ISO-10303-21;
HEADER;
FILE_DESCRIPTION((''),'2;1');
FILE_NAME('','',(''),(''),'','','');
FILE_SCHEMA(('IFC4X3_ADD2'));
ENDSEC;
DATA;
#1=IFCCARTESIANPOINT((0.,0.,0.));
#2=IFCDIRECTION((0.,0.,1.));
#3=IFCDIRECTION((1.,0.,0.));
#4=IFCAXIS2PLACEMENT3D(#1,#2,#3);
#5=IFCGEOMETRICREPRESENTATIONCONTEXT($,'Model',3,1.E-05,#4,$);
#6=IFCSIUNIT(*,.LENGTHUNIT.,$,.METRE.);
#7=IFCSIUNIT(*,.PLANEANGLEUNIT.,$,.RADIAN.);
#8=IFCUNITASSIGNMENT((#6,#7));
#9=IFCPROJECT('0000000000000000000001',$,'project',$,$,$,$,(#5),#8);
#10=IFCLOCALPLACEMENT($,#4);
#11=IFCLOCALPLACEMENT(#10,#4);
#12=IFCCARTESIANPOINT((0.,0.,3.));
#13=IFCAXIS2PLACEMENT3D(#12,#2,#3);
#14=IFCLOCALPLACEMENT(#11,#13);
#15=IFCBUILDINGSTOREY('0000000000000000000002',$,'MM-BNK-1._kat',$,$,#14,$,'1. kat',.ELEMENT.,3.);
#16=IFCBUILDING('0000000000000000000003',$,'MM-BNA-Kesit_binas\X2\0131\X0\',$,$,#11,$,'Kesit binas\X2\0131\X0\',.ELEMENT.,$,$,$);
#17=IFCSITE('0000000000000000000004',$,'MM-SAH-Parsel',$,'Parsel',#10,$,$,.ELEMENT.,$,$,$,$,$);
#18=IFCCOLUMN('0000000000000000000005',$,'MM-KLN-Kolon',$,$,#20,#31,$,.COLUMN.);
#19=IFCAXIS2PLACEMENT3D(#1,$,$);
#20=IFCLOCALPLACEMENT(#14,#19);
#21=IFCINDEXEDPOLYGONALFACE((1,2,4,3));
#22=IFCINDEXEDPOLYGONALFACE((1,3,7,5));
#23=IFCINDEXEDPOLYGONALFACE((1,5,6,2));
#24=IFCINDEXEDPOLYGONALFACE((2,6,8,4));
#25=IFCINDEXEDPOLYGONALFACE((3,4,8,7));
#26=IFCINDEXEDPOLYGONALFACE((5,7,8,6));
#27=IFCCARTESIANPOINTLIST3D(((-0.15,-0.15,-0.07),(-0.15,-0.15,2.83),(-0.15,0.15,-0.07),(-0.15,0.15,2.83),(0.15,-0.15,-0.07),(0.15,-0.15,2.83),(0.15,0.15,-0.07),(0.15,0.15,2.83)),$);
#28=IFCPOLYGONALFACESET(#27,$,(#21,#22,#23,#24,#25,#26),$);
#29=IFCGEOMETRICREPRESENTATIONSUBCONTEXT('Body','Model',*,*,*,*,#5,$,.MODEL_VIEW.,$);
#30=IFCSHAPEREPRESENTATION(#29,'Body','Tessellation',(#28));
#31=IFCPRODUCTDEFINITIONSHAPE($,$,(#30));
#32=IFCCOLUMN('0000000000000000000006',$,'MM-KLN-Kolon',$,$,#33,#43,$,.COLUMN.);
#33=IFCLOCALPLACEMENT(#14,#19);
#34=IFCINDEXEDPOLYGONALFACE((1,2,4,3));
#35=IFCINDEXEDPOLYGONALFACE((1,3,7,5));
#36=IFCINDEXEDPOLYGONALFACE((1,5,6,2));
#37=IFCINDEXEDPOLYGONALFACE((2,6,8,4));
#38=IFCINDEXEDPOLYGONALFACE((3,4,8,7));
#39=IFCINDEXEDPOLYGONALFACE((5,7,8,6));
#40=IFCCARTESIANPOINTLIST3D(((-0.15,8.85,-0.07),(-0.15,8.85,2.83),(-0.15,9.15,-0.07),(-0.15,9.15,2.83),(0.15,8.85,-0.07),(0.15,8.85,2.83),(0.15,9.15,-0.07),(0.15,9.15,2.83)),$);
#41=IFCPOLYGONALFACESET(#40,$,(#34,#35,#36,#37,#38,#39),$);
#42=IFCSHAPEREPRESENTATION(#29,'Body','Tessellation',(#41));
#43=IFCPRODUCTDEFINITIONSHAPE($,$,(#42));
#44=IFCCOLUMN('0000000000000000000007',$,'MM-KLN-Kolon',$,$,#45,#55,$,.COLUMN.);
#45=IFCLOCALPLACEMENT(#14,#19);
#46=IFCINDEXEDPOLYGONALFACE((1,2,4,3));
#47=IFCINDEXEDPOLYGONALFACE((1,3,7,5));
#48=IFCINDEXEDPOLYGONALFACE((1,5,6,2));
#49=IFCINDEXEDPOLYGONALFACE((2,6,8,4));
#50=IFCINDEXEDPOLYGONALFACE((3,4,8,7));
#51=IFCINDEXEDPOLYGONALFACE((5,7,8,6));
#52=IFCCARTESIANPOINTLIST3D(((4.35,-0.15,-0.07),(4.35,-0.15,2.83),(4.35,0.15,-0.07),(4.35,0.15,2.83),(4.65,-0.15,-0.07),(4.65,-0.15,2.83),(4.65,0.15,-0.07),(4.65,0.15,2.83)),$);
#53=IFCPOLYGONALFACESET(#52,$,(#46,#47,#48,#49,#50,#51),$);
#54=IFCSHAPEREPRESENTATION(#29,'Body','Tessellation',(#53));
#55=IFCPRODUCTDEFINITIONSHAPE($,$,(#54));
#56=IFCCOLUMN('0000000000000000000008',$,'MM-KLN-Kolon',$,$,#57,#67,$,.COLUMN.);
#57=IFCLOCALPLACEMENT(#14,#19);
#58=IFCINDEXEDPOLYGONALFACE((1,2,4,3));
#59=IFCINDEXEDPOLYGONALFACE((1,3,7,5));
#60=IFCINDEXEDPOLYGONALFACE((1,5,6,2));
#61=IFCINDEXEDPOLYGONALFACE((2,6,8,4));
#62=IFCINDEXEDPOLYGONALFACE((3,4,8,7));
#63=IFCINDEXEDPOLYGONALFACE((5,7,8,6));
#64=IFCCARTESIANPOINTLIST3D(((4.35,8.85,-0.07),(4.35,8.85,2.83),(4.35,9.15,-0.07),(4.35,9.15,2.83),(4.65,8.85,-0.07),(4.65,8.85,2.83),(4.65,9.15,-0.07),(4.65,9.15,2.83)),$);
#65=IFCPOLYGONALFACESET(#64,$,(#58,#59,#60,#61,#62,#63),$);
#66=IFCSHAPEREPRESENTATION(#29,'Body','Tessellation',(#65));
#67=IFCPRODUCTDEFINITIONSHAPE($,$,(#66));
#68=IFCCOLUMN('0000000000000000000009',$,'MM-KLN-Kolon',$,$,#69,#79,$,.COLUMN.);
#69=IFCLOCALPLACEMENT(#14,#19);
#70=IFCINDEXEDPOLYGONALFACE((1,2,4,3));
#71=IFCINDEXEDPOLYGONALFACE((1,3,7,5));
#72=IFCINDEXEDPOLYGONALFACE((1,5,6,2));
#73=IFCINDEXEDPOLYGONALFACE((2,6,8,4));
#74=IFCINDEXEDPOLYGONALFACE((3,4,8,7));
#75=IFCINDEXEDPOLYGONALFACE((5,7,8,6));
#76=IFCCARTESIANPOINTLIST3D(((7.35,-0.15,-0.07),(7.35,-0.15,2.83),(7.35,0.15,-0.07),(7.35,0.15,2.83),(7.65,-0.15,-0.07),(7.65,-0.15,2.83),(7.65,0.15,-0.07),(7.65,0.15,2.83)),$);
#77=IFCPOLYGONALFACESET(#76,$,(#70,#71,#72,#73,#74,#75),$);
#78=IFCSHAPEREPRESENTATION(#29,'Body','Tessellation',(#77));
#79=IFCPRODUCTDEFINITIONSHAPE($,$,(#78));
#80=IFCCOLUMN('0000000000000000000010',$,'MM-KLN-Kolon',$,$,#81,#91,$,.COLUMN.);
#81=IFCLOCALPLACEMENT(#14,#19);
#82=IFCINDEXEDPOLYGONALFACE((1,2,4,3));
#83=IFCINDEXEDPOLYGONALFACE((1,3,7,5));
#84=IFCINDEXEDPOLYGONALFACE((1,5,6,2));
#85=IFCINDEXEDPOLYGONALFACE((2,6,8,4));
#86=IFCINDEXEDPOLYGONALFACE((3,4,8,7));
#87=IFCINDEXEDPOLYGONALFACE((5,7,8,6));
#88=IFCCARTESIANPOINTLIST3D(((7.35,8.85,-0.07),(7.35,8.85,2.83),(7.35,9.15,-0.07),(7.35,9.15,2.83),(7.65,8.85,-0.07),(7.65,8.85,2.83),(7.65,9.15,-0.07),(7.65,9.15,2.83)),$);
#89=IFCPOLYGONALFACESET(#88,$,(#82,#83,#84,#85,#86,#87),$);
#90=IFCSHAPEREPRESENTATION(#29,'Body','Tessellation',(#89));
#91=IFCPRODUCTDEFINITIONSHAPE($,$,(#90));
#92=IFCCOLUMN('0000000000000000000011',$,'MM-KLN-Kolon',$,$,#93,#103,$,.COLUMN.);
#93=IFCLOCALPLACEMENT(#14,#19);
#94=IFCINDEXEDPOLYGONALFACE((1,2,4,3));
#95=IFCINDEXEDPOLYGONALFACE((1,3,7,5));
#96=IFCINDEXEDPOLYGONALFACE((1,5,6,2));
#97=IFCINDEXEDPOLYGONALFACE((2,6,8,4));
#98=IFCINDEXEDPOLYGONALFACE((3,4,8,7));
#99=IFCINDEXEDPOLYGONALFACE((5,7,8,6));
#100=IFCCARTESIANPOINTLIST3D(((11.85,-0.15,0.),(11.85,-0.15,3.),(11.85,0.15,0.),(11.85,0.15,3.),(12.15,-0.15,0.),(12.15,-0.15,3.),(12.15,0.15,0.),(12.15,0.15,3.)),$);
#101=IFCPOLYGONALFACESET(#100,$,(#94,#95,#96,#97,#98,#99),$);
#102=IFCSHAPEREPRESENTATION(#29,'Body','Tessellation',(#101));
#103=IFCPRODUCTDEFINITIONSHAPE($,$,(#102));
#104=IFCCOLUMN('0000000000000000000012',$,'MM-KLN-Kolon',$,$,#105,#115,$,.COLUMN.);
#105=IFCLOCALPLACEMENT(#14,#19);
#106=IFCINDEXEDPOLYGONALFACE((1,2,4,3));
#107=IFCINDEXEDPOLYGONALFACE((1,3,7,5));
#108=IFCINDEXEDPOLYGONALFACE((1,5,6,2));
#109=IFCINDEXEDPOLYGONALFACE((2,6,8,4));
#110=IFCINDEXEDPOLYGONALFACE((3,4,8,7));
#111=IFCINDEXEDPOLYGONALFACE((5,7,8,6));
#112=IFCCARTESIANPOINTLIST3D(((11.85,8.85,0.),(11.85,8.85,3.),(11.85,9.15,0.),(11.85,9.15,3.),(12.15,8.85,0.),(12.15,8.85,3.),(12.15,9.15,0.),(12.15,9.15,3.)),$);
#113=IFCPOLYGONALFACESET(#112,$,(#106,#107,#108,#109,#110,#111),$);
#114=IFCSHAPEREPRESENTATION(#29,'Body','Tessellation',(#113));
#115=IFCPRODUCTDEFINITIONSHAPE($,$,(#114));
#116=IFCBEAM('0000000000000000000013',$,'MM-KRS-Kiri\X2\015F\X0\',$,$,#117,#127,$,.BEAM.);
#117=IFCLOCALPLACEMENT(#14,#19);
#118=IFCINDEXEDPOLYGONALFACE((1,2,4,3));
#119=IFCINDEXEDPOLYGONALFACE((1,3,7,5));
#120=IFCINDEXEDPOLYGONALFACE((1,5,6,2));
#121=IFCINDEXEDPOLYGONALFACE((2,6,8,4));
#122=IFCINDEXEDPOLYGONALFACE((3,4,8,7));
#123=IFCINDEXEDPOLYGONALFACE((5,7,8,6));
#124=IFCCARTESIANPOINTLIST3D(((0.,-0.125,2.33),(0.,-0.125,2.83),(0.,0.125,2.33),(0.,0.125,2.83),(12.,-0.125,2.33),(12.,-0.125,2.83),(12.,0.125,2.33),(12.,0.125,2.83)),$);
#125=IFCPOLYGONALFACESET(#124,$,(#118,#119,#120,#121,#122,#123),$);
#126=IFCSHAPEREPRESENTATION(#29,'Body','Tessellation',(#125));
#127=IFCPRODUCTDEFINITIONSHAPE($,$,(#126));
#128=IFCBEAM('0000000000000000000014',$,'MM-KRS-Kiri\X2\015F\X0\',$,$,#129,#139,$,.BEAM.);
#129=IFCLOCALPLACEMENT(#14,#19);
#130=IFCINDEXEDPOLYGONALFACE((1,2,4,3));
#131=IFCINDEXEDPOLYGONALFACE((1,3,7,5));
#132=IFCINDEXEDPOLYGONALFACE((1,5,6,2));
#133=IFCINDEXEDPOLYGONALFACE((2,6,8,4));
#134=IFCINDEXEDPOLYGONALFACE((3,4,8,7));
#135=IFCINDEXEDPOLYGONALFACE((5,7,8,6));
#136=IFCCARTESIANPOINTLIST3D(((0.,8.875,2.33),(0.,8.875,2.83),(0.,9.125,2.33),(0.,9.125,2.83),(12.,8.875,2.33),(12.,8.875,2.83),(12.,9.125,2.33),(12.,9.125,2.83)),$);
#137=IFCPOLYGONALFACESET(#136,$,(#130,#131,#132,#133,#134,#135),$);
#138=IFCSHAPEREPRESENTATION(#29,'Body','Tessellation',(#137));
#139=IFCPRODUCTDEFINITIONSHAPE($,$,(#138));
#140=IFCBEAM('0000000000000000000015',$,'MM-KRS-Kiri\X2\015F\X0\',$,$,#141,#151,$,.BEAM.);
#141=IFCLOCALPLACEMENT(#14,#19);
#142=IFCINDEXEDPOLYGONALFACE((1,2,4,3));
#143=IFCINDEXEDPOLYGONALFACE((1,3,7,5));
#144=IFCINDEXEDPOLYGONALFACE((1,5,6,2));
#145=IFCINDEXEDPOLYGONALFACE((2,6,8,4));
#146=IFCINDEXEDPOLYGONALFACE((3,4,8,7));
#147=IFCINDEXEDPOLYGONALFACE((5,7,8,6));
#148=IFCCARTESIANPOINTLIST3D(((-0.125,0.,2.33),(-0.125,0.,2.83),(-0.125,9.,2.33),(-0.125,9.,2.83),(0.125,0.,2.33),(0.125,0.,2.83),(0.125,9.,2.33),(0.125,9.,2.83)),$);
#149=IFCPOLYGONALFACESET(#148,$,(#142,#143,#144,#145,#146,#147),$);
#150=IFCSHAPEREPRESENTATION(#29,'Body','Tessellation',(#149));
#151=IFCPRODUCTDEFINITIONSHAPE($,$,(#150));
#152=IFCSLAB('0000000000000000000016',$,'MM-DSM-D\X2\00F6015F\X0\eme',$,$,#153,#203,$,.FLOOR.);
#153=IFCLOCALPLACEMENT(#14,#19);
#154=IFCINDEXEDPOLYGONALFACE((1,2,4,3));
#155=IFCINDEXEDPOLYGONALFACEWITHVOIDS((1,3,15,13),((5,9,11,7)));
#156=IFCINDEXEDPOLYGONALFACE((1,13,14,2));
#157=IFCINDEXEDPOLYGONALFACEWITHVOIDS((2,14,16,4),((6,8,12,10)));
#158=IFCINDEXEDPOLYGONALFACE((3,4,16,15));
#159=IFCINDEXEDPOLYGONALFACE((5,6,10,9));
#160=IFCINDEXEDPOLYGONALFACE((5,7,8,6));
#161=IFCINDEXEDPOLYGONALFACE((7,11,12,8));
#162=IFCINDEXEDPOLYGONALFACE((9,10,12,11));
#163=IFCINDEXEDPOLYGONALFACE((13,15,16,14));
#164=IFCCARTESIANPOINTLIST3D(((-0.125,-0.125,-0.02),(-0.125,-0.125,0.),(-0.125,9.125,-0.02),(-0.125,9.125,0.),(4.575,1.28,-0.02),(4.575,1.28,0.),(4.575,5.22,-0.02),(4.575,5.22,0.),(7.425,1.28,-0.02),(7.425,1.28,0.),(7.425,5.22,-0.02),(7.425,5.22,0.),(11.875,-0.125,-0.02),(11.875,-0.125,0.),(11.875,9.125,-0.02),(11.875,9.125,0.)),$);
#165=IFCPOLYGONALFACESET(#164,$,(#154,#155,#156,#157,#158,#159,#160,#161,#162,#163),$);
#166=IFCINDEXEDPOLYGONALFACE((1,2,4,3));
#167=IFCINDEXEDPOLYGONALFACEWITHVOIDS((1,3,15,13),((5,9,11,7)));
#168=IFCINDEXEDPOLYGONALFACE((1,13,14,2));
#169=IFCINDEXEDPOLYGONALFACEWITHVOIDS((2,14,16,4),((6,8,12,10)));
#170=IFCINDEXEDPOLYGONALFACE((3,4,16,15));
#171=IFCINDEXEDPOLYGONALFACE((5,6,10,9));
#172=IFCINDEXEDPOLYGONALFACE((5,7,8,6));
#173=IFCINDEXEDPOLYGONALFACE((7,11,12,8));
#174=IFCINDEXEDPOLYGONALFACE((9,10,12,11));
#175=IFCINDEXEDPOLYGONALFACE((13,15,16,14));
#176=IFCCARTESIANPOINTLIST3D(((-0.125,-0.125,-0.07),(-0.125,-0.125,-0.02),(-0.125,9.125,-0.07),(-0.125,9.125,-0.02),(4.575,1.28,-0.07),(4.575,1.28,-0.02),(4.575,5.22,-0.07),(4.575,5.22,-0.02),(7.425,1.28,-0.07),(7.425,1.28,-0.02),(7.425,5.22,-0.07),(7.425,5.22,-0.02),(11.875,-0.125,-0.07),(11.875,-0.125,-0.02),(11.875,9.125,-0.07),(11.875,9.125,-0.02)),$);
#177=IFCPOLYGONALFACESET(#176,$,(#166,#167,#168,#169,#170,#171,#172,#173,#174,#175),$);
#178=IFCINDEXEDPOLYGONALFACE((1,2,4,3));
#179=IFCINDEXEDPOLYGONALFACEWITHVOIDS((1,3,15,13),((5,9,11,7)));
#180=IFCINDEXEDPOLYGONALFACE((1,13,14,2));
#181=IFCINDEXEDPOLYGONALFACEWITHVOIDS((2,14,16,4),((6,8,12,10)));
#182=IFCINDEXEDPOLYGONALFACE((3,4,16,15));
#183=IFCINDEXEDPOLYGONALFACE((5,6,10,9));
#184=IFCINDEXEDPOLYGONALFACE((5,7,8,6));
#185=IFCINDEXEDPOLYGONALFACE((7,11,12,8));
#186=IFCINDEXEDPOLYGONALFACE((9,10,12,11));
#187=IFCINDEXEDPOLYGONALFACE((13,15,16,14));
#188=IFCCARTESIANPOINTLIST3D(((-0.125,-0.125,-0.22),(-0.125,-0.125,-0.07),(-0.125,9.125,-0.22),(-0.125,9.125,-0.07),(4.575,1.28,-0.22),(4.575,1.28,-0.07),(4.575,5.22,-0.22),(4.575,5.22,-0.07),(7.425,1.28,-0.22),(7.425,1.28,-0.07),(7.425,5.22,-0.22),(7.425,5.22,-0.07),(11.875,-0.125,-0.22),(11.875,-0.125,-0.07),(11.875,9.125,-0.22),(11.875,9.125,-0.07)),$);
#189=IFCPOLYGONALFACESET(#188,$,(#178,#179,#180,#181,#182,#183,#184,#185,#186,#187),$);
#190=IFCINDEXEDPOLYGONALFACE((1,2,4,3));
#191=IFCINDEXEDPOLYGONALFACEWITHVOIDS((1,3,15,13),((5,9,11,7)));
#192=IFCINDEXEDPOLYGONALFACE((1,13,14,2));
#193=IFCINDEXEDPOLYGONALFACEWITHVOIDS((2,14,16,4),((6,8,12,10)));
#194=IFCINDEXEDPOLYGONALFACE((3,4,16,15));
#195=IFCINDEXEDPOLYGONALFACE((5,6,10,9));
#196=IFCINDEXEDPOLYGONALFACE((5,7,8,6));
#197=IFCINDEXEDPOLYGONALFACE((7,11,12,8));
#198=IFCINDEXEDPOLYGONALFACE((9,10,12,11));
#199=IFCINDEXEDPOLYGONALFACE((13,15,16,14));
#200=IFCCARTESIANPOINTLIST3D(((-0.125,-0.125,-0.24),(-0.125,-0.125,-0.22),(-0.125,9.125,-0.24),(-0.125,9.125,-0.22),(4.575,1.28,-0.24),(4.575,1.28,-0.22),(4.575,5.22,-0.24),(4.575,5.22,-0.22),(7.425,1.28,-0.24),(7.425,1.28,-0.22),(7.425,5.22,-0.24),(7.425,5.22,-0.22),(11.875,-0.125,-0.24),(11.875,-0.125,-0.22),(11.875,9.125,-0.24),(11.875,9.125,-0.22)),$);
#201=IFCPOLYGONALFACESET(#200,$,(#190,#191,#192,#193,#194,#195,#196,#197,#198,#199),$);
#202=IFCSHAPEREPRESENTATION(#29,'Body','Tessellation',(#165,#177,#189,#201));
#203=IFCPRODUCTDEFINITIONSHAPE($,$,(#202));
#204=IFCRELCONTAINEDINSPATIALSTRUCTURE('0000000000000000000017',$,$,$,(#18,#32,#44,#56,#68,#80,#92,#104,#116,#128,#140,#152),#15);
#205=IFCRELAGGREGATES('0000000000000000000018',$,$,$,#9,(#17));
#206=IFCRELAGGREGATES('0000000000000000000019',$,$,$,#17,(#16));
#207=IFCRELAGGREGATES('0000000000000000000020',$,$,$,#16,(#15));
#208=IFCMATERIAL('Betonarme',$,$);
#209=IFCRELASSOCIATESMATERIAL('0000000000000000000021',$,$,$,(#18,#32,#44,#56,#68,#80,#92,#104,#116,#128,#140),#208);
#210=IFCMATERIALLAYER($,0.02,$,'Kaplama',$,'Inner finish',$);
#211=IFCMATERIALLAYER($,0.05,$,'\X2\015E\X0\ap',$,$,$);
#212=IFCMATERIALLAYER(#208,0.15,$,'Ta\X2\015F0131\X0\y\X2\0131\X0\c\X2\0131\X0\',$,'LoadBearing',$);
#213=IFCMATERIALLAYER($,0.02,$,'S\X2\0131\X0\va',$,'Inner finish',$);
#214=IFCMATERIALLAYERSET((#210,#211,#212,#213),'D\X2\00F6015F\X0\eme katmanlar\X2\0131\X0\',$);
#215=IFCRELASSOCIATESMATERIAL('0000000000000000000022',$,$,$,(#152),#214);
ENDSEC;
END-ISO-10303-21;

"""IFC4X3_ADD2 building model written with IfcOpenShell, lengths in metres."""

from ifc_helpers import new_model, si_unit, frame, origin, origin_with_axes, place, context, subcontext, project, spatial, polyline, outline, extrude, material, layer, layer_set, layer_usage, element, save


model = new_model("IFC4X3_ADD2")

# Units and contexts
model_context = context("Model", 3, precision=1e-05, world=origin_with_axes())
body_context = subcontext(model_context, "Body", "Model", "MODEL_VIEW")
ifc_project = project(units=[si_unit("LENGTHUNIT", "METRE"), si_unit("PLANEANGLEUNIT", "RADIAN")], contexts=[model_context])

# Site, building, storey
site_placement = place(None, origin_with_axes())
site = spatial("IfcSite", under=ifc_project, at=site_placement, Name="MM-SAH-Parsel", ObjectType="Parsel", CompositionType="ELEMENT")
building_placement = place(site_placement, origin_with_axes())
building = spatial("IfcBuilding", under=site, at=building_placement, Name="MM-BNA-Kesit_binası", LongName="Kesit binası", CompositionType="ELEMENT")
storey_placement = place(building_placement, frame((0.0, 0.0, 3.0), z_axis=(0.0, 0.0, 1.0), x_axis=(1.0, 0.0, 0.0)))
storey = spatial("IfcBuildingStorey", under=building, at=storey_placement, Name="MM-BNK-1._kat", LongName="1. kat", CompositionType="ELEMENT", Elevation=3.0)

# Columns
ifc_material_1 = material(Name="Betonarme")
column_1_placement = place(storey_placement, origin_with_axes())
element("IfcColumn", 1, at=column_1_placement, inside=storey, material=ifc_material_1, Name="MM-KLN-Kolon", PredefinedType="COLUMN", context=body_context, shape_type="SweptSolid", body=[
    extrude(outline(polyline([(-0.15, -0.15), (0.15, -0.15), (0.15, 0.15), (-0.15, 0.15), (-0.15, -0.15)])), frame((0.0, 0.0, -0.07)), (0.0, 0.0, 1.0), 2.9),
])
column_2_placement = place(storey_placement, origin_with_axes())
element("IfcColumn", 2, at=column_2_placement, inside=storey, material=ifc_material_1, Name="MM-KLN-Kolon", PredefinedType="COLUMN", context=body_context, shape_type="SweptSolid", body=[
    extrude(outline(polyline([(-0.15, 8.85), (0.15, 8.85), (0.15, 9.15), (-0.15, 9.15), (-0.15, 8.85)])), frame((0.0, 0.0, -0.07)), (0.0, 0.0, 1.0), 2.9),
])
column_3_placement = place(storey_placement, origin_with_axes())
element("IfcColumn", 3, at=column_3_placement, inside=storey, material=ifc_material_1, Name="MM-KLN-Kolon", PredefinedType="COLUMN", context=body_context, shape_type="SweptSolid", body=[
    extrude(outline(polyline([(4.35, -0.15), (4.65, -0.15), (4.65, 0.15), (4.35, 0.15), (4.35, -0.15)])), frame((0.0, 0.0, -0.07)), (0.0, 0.0, 1.0), 2.9),
])
column_4_placement = place(storey_placement, origin_with_axes())
element("IfcColumn", 4, at=column_4_placement, inside=storey, material=ifc_material_1, Name="MM-KLN-Kolon", PredefinedType="COLUMN", context=body_context, shape_type="SweptSolid", body=[
    extrude(outline(polyline([(4.35, 8.85), (4.65, 8.85), (4.65, 9.15), (4.35, 9.15), (4.35, 8.85)])), frame((0.0, 0.0, -0.07)), (0.0, 0.0, 1.0), 2.9),
])
column_5_placement = place(storey_placement, origin_with_axes())
element("IfcColumn", 5, at=column_5_placement, inside=storey, material=ifc_material_1, Name="MM-KLN-Kolon", PredefinedType="COLUMN", context=body_context, shape_type="SweptSolid", body=[
    extrude(outline(polyline([(7.35, -0.15), (7.65, -0.15), (7.65, 0.15), (7.35, 0.15), (7.35, -0.15)])), frame((0.0, 0.0, -0.07)), (0.0, 0.0, 1.0), 2.9),
])
column_6_placement = place(storey_placement, origin_with_axes())
element("IfcColumn", 6, at=column_6_placement, inside=storey, material=ifc_material_1, Name="MM-KLN-Kolon", PredefinedType="COLUMN", context=body_context, shape_type="SweptSolid", body=[
    extrude(outline(polyline([(7.35, 8.85), (7.65, 8.85), (7.65, 9.15), (7.35, 9.15), (7.35, 8.85)])), frame((0.0, 0.0, -0.07)), (0.0, 0.0, 1.0), 2.9),
])
column_7_placement = place(storey_placement, origin_with_axes())
element("IfcColumn", 7, at=column_7_placement, inside=storey, material=ifc_material_1, Name="MM-KLN-Kolon", PredefinedType="COLUMN", context=body_context, shape_type="SweptSolid", body=[
    extrude(outline(polyline([(11.85, -0.15), (12.15, -0.15), (12.15, 0.15), (11.85, 0.15), (11.85, -0.15)])), origin(), (0.0, 0.0, 1.0), 3.0),
])
column_8_placement = place(storey_placement, origin_with_axes())
element("IfcColumn", 8, at=column_8_placement, inside=storey, material=ifc_material_1, Name="MM-KLN-Kolon", PredefinedType="COLUMN", context=body_context, shape_type="SweptSolid", body=[
    extrude(outline(polyline([(11.85, 8.85), (12.15, 8.85), (12.15, 9.15), (11.85, 9.15), (11.85, 8.85)])), origin(), (0.0, 0.0, 1.0), 3.0),
])

# Beams
beam_1_placement = place(storey_placement, origin_with_axes())
element("IfcBeam", 9, at=beam_1_placement, inside=storey, material=ifc_material_1, Name="MM-KRS-Kiriş", PredefinedType="BEAM", context=body_context, shape_type="SweptSolid", body=[
    extrude(outline(polyline([(0.0, 0.125), (12.0, 0.125), (12.0, -0.125), (0.0, -0.125), (0.0, 0.125)])), frame((0.0, 0.0, 2.33)), (0.0, 0.0, 1.0), 0.5),
])
beam_2_placement = place(storey_placement, origin_with_axes())
element("IfcBeam", 10, at=beam_2_placement, inside=storey, material=ifc_material_1, Name="MM-KRS-Kiriş", PredefinedType="BEAM", context=body_context, shape_type="SweptSolid", body=[
    extrude(outline(polyline([(12.0, 8.875), (0.0, 8.875), (0.0, 9.125), (12.0, 9.125), (12.0, 8.875)])), frame((0.0, 0.0, 2.33)), (0.0, 0.0, 1.0), 0.5),
])
beam_3_placement = place(storey_placement, origin_with_axes())
element("IfcBeam", 11, at=beam_3_placement, inside=storey, material=ifc_material_1, Name="MM-KRS-Kiriş", PredefinedType="BEAM", context=body_context, shape_type="SweptSolid", body=[
    extrude(outline(polyline([(0.125, 9.0), (0.125, 0.0), (-0.125, 0.0), (-0.125, 9.0), (0.125, 9.0)])), frame((0.0, 0.0, 2.33)), (0.0, 0.0, 1.0), 0.5),
])

# Slab, opening
ifc_layer_1 = layer(None, 0.02, Name="Kaplama", Category="Inner finish")
ifc_layer_2 = layer(None, 0.05, Name="Şap")
ifc_layer_3 = layer(ifc_material_1, 0.15, Name="Taşıyıcı", Category="LoadBearing")
ifc_layer_4 = layer(None, 0.02, Name="Sıva", Category="Inner finish")
ifc_layer_set_1 = layer_set([ifc_layer_1, ifc_layer_2, ifc_layer_3, ifc_layer_4], Name="Döşeme katmanları")
ifc_layer_usage_1 = layer_usage(ifc_layer_set_1, "AXIS3", "NEGATIVE", 0.0)
slab_1_placement = place(storey_placement, origin_with_axes())
slab_1 = element("IfcSlab", 12, at=slab_1_placement, inside=storey, material=ifc_layer_usage_1, Name="MM-DSM-Döşeme", PredefinedType="FLOOR", context=body_context, shape_type="SweptSolid", body=[
    extrude(outline(polyline([(-0.125, -0.125), (11.875, -0.125), (11.875, 9.125), (-0.125, 9.125), (-0.125, -0.125)])), frame((0.0, 0.0, -0.02)), (0.0, 0.0, 1.0), 0.02),
    extrude(outline(polyline([(-0.125, -0.125), (11.875, -0.125), (11.875, 9.125), (-0.125, 9.125), (-0.125, -0.125)])), frame((0.0, 0.0, -0.07)), (0.0, 0.0, 1.0), 0.05),
    extrude(outline(polyline([(-0.125, -0.125), (11.875, -0.125), (11.875, 9.125), (-0.125, 9.125), (-0.125, -0.125)])), frame((0.0, 0.0, -0.22)), (0.0, 0.0, 1.0), 0.15),
    extrude(outline(polyline([(-0.125, -0.125), (11.875, -0.125), (11.875, 9.125), (-0.125, 9.125), (-0.125, -0.125)])), frame((0.0, 0.0, -0.24)), (0.0, 0.0, 1.0), 0.02),
])
opening_1_placement = place(storey_placement, origin_with_axes())
element("IfcOpeningElement", 13, at=opening_1_placement, cuts=slab_1, PredefinedType="OPENING", context=body_context, shape_type="SweptSolid", body=[
    extrude(outline(polyline([(4.575, 1.28), (4.575, 5.22), (7.425, 5.22), (7.425, 1.28), (4.575, 1.28)])), frame((0.0, 0.0, -0.24)), (0.0, 0.0, 1.0), 0.24),
])

save(model, "model.ifc")
